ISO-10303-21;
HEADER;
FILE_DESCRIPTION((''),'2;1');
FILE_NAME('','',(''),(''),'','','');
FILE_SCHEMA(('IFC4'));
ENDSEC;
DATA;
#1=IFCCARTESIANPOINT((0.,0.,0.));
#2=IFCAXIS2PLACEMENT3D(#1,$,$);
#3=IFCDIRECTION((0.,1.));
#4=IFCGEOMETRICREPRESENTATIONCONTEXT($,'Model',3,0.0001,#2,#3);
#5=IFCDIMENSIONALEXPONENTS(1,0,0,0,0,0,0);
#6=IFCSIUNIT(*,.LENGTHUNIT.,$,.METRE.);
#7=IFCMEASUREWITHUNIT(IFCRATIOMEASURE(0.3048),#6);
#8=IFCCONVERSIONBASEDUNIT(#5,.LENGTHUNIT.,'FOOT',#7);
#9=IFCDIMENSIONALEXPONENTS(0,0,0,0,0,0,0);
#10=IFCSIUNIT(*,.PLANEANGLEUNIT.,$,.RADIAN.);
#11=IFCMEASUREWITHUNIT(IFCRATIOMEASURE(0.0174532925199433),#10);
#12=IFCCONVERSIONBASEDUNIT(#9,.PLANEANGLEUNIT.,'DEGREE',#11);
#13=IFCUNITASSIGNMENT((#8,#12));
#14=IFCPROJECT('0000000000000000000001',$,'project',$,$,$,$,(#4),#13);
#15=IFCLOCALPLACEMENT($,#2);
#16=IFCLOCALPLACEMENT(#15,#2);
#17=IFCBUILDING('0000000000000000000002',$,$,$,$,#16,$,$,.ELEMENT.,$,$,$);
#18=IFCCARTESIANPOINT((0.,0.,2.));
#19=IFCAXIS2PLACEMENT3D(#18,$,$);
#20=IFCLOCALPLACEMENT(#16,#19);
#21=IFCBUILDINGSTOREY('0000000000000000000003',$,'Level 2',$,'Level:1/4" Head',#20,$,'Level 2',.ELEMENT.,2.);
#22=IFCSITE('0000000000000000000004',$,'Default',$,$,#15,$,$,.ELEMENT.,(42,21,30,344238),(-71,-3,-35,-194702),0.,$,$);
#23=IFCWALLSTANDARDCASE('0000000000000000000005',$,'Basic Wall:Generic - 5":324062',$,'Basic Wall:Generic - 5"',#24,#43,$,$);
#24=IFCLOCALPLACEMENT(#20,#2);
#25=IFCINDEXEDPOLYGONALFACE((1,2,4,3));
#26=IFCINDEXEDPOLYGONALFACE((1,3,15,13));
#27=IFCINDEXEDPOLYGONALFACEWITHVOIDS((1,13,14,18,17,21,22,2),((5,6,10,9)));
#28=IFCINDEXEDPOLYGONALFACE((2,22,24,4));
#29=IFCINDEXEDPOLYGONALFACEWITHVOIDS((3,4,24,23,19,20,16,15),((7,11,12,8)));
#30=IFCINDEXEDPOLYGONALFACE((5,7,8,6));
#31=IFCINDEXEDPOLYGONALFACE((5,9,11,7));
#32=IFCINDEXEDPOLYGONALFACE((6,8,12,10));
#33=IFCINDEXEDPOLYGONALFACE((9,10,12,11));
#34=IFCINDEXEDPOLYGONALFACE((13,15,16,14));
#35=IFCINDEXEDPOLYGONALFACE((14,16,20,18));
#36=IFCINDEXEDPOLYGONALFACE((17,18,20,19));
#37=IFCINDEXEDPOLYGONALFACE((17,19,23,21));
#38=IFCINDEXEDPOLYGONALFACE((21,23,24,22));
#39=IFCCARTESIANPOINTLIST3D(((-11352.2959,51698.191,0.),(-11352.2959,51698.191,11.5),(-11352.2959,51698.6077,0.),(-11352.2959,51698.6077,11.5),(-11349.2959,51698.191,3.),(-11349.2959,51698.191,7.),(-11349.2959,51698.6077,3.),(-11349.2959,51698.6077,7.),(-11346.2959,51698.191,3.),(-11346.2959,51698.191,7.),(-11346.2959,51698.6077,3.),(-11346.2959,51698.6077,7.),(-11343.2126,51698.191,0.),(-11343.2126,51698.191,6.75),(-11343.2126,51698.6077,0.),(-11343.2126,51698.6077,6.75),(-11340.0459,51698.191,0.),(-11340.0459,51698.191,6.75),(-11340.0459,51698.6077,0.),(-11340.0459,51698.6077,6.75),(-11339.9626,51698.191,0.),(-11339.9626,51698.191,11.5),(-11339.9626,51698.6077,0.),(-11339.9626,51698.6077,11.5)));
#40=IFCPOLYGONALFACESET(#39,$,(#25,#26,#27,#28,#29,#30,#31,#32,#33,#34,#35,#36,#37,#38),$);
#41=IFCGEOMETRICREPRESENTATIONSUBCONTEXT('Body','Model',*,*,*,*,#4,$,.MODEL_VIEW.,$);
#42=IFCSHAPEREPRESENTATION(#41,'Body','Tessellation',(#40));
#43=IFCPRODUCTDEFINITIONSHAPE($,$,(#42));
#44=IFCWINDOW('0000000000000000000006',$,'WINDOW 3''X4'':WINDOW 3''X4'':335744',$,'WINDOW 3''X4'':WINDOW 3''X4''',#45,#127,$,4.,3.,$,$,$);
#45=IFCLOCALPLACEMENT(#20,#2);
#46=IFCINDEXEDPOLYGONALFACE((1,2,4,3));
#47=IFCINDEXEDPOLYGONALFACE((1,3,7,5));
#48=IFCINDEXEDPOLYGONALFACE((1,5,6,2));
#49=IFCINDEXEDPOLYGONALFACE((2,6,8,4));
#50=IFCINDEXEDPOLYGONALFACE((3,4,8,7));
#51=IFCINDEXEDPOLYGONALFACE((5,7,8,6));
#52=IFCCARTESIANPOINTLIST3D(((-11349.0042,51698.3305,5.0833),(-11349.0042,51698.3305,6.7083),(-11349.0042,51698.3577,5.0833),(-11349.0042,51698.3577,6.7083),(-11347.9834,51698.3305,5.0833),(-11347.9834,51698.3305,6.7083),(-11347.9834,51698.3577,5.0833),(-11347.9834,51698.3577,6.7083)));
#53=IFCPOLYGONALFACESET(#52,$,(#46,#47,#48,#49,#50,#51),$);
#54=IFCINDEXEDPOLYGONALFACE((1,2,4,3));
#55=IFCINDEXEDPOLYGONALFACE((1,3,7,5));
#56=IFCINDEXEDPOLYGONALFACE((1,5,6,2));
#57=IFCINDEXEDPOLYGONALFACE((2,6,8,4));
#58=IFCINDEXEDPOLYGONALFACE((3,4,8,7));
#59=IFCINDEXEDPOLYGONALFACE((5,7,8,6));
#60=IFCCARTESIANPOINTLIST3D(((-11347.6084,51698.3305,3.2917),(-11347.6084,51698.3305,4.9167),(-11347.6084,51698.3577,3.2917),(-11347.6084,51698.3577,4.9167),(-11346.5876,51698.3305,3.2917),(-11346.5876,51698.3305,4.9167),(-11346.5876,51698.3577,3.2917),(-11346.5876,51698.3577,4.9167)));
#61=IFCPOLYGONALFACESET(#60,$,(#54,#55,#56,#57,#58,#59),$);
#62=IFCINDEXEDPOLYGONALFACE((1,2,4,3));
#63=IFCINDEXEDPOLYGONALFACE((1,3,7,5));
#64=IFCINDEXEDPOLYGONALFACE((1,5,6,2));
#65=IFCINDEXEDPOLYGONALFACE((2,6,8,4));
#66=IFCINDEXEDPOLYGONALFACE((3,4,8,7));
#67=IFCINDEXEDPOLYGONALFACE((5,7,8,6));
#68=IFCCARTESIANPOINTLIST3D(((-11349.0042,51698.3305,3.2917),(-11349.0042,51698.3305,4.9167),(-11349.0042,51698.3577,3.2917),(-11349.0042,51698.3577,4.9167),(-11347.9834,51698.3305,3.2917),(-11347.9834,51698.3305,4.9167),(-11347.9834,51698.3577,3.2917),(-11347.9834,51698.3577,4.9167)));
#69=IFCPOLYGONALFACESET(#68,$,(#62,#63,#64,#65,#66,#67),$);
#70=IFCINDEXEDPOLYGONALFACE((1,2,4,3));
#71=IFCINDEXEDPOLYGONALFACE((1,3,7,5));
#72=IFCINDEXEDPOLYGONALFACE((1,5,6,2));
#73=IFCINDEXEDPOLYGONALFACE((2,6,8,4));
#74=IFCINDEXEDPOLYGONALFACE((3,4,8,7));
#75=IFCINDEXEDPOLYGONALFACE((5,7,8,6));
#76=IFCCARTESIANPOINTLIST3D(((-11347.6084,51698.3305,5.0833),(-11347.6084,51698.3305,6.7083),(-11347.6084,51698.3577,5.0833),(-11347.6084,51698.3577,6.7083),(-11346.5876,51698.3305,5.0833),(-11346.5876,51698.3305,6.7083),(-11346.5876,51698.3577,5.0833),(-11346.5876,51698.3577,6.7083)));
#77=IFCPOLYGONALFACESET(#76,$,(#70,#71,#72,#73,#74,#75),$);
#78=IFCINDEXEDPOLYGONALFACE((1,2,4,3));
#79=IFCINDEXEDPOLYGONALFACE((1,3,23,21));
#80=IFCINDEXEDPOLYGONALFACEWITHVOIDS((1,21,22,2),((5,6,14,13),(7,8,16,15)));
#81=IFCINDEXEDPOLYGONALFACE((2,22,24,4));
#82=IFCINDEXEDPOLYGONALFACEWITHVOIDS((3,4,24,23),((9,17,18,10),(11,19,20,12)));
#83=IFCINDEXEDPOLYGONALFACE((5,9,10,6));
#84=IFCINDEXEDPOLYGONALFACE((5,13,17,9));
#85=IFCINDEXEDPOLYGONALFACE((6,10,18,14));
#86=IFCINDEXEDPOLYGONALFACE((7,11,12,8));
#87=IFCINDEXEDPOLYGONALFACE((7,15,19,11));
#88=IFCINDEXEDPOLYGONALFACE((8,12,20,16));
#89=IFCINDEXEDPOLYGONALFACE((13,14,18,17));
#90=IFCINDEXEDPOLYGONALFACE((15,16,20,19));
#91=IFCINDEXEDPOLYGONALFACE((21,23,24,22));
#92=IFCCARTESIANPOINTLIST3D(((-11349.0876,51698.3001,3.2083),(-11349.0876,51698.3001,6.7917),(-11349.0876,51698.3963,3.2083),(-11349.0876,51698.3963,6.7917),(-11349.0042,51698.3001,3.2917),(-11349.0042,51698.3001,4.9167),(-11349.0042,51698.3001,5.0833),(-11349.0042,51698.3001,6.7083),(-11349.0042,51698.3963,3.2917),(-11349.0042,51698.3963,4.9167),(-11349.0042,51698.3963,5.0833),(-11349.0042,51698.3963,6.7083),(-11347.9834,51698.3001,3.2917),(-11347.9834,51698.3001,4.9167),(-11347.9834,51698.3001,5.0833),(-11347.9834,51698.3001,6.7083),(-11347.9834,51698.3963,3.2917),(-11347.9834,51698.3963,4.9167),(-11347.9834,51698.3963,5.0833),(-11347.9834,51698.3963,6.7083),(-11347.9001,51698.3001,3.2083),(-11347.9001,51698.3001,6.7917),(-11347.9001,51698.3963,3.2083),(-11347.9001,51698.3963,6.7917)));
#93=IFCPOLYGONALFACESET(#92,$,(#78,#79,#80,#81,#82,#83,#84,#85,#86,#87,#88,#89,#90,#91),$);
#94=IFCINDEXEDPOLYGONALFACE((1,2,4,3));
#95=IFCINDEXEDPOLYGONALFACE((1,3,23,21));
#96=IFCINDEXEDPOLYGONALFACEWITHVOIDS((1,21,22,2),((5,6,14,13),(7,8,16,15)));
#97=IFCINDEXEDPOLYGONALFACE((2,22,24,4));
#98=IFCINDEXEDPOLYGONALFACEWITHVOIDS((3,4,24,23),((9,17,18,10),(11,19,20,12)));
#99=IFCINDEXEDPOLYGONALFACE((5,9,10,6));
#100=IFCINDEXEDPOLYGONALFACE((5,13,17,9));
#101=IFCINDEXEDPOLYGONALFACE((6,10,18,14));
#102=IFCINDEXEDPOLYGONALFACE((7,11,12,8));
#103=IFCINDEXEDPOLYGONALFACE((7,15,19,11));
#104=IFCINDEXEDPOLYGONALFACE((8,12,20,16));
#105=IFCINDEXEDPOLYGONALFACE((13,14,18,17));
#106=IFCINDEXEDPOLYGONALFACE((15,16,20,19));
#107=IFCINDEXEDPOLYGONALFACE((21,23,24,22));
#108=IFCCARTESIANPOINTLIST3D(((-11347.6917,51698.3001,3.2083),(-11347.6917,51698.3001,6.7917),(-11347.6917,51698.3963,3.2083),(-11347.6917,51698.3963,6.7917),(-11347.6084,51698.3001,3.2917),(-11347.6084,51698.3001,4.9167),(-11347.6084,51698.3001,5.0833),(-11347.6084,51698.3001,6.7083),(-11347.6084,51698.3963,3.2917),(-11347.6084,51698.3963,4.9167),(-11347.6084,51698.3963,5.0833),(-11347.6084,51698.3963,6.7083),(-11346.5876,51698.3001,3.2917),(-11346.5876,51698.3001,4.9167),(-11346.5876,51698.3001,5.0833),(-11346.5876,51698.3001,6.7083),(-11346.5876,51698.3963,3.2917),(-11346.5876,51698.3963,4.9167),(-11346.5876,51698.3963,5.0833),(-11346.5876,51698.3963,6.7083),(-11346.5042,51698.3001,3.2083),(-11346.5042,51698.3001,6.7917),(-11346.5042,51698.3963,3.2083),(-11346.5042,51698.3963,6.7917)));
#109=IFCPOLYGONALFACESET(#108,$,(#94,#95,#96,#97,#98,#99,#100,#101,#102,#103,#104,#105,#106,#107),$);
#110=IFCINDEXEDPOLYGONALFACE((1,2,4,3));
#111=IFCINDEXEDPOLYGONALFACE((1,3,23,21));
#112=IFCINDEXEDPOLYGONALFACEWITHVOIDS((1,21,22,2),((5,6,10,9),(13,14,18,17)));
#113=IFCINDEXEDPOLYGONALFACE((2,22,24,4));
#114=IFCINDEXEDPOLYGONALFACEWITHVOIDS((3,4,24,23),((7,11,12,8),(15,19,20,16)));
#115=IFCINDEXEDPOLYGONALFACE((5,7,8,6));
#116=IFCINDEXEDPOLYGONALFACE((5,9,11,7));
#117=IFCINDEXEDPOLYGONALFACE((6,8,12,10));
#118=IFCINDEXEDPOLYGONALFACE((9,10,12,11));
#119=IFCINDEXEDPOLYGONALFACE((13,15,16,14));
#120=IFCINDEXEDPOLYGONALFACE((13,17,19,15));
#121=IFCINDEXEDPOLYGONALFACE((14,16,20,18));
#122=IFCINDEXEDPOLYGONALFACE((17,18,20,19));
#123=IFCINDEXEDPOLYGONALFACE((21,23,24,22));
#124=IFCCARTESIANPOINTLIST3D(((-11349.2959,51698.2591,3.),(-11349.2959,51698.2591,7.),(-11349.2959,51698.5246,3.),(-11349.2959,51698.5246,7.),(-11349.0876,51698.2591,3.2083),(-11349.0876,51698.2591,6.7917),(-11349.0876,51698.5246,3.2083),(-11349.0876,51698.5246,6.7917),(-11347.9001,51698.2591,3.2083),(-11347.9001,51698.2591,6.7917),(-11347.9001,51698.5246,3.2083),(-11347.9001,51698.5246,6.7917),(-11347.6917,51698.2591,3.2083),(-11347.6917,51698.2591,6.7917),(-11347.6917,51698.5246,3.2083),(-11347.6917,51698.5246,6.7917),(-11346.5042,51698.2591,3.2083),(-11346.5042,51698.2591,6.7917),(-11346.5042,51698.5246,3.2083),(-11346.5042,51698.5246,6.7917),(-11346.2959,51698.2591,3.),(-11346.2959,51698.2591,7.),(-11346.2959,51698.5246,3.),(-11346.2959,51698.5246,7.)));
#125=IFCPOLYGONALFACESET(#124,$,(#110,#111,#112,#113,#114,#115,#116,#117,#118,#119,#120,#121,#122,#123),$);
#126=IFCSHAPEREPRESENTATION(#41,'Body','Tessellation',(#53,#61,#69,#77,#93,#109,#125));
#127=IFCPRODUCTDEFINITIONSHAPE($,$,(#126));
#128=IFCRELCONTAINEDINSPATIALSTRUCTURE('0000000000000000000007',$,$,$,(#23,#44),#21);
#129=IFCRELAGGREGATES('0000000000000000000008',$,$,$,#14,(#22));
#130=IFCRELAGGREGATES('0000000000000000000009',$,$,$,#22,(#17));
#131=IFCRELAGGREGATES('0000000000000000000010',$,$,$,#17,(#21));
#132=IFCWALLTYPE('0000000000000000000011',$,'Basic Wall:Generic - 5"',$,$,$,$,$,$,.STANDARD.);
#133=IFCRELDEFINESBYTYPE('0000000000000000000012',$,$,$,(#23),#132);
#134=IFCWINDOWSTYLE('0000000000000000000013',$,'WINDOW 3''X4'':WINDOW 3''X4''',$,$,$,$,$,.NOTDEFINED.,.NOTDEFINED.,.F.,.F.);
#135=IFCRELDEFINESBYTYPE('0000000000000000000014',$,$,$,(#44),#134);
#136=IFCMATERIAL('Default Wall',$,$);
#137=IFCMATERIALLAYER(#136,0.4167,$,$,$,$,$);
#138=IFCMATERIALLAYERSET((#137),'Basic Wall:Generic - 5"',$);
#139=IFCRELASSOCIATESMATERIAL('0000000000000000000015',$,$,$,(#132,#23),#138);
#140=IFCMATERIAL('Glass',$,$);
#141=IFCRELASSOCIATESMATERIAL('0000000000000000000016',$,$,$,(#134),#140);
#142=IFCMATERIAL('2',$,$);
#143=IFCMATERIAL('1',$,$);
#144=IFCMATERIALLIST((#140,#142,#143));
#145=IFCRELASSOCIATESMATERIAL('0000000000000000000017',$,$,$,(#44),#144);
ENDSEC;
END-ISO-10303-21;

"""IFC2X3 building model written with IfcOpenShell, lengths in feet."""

from ifc_helpers import new_model, entity, si_unit, converted_unit, direction, frame, frame_2d, origin, origin_2d_with_axis, place, context, subcontext, project, spatial, polyline, rectangle, outline, extrude, source, transform, mapped, material, material_list, layer, layer_set, layer_usage, type_object, type_shapes, element, fill, save


model = new_model("IFC2X3")

# Units and contexts
model_context = context("Model", 3, precision=0.0001, world=origin(), true_north=direction((0.0, 1.0)))
body_context = subcontext(model_context, "Body", "Model", "MODEL_VIEW")
ifc_project = project(units=[converted_unit("LENGTHUNIT", "FOOT", entity("IfcRatioMeasure", 0.3048), si_unit("LENGTHUNIT", "METRE"), dimensions=[1, 0, 0, 0, 0, 0, 0]), converted_unit("PLANEANGLEUNIT", "DEGREE", entity("IfcRatioMeasure", 0.0174532925199433), si_unit("PLANEANGLEUNIT", "RADIAN"), dimensions=[0, 0, 0, 0, 0, 0, 0])], contexts=[model_context])

# Site, building, storey
site_placement = place(None, origin())
site = spatial("IfcSite", under=ifc_project, at=site_placement, Name="Default", CompositionType="ELEMENT", RefLatitude=(42, 21, 30, 344238), RefLongitude=(-71, -3, -35, -194702), RefElevation=0.0)
building_placement = place(site_placement, origin())
building = spatial("IfcBuilding", under=site, at=building_placement, CompositionType="ELEMENT")
storey_placement = place(building_placement, frame((0.0, 0.0, 2.0)))
storey = spatial("IfcBuildingStorey", under=building, at=storey_placement, Name="Level 2", ObjectType="Level:1/4\" Head", LongName="Level 2", CompositionType="ELEMENT", Elevation=2.0)

# Wall, openings, window
ifc_material_1 = material(Name="Default Wall")
ifc_layer_1 = layer(ifc_material_1, 0.4167)
ifc_layer_set_1 = layer_set([ifc_layer_1], Name="Basic Wall:Generic - 5\"")
wall_type = type_object("IfcWallType", Name="Basic Wall:Generic - 5\"", PredefinedType="STANDARD", material=ifc_layer_set_1)
ifc_material_2 = material(Name="Glass")
ifc_material_3 = material(Name="2")
ifc_material_4 = material(Name="1")
window_style = type_object("IfcWindowStyle", Name="WINDOW 3'X4':WINDOW 3'X4'", ConstructionType="NOTDEFINED", OperationType="NOTDEFINED", ParameterTakesPrecedence=False, Sizeable=False, material=ifc_material_2)
shared_shape = source(origin(), body_context, "Body", "SweptSolid", [
    extrude(rectangle(XDim=0.0272, YDim=1.0208, at=origin_2d_with_axis()), frame((2.1979, 0.2636, 2.0833), z_axis=(0.0, 0.0, 1.0), x_axis=(0.0, 1.0, 0.0)), (0.0, 0.0, 1.0), 1.625),
    extrude(rectangle(XDim=0.0272, YDim=1.0208, at=origin_2d_with_axis()), frame((0.8021, 0.2636, 0.2917), z_axis=(0.0, 0.0, 1.0), x_axis=(0.0, 1.0, 0.0)), (0.0, 0.0, 1.0), 1.625),
    extrude(rectangle(XDim=0.0272, YDim=1.0208, at=origin_2d_with_axis()), frame((2.1979, 0.2636, 0.2917), z_axis=(0.0, 0.0, 1.0), x_axis=(0.0, 1.0, 0.0)), (0.0, 0.0, 1.0), 1.625),
    extrude(rectangle(XDim=0.0272, YDim=1.0208, at=origin_2d_with_axis()), frame((0.8021, 0.2636, 2.0833), z_axis=(0.0, 0.0, 1.0), x_axis=(0.0, 1.0, 0.0)), (0.0, 0.0, 1.0), 1.625),
    extrude(outline(polyline([(-0.5938, -1.7917), (0.5938, -1.7917), (0.5938, 1.7917), (-0.5938, 1.7917), (-0.5938, -1.7917)]), holes=[polyline([(-0.5104, -0.0833), (0.5104, -0.0833), (0.5104, -1.7083), (-0.5104, -1.7083), (-0.5104, -0.0833)]), polyline([(-0.5104, 1.7083), (0.5104, 1.7083), (0.5104, 0.0833), (-0.5104, 0.0833), (-0.5104, 1.7083)])]), frame((2.1979, 0.2114, 2.0), z_axis=(0.0, 1.0, 0.0), x_axis=(-1.0, 0.0, 0.0)), (0.0, 0.0, 1.0), 0.0962),
    extrude(outline(polyline([(-1.7917, -0.5937), (1.7917, -0.5937), (1.7917, 0.5937), (-1.7917, 0.5937), (-1.7917, -0.5937)]), holes=[polyline([(0.0833, -0.5104), (0.0833, 0.5104), (1.7083, 0.5104), (1.7083, -0.5104), (0.0833, -0.5104)]), polyline([(-1.7083, -0.5104), (-1.7083, 0.5104), (-0.0833, 0.5104), (-0.0833, -0.5104), (-1.7083, -0.5104)])]), frame((0.8021, 0.2114, 2.0), z_axis=(0.0, 1.0, 0.0), x_axis=(0.0, 0.0, -1.0)), (0.0, 0.0, 1.0), 0.0962),
    extrude(outline(polyline([(-1.5, -2.0), (1.5, -2.0), (1.5, 2.0), (-1.5, 2.0), (-1.5, -2.0)]), holes=[polyline([(-0.1042, 1.7917), (-0.1042, -1.7917), (-1.2917, -1.7917), (-1.2917, 1.7917), (-0.1042, 1.7917)]), polyline([(0.1042, -1.7917), (0.1042, 1.7917), (1.2917, 1.7917), (1.2917, -1.7917), (0.1042, -1.7917)])]), frame((1.5, 0.0831, 2.0), z_axis=(0.0, 1.0, 0.0), x_axis=(1.0, 0.0, 0.0)), (0.0, 0.0, 1.0), 0.2655),
])
type_shapes(window_style, [shared_shape])
ifc_layer_usage_1 = layer_usage(ifc_layer_set_1, "AXIS2", "NEGATIVE", 0.2083)
wall_1_placement = place(storey_placement, frame((-11352.2959, 51698.3993, 0.0)))
wall_1 = element("IfcWallStandardCase", 1, at=wall_1_placement, inside=storey, type_object=wall_type, material=ifc_layer_usage_1, Name="Basic Wall:Generic - 5\":324062", ObjectType="Basic Wall:Generic - 5\"", context=body_context, shape_type="SweptSolid", body=[
    extrude(rectangle(XDim=12.3333, YDim=0.4167, at=frame_2d((6.1667, 0.0), x_axis=(-1.0, 0.0))), origin(), (0.0, 0.0, 1.0), 11.5),
])
opening_1_placement = place(wall_1_placement, frame((9.0833, -0.2083, 0.0)))
element("IfcOpeningElement", 2, at=opening_1_placement, cuts=wall_1, ObjectType="Opening", context=body_context, shape_type="SweptSolid", body=[
    extrude(rectangle(XDim=6.75, YDim=3.1667, at=frame_2d((3.375, 1.5833), x_axis=(1.0, 0.0))), frame((0.0, 0.0, 0.0), z_axis=(0.0, 1.0, 0.0), x_axis=(0.0, 0.0, 1.0)), (0.0, 0.0, 1.0), 0.4167),
])
opening_2_placement = place(wall_1_placement, frame((6.0, 0.2083, 3.0)))
opening_2 = element("IfcOpeningElement", 3, at=opening_2_placement, cuts=wall_1, ObjectType="Opening", context=body_context, shape_type="SweptSolid", body=[
    extrude(rectangle(XDim=4.0, YDim=3.0, at=frame_2d((2.0, 1.5), x_axis=(-1.0, 0.0))), frame((0.0, 0.0, 0.0), z_axis=(0.0, -1.0, 0.0), x_axis=(0.0, 0.0, 1.0)), (0.0, 0.0, 1.0), 0.4167),
])
ifc_material_list_1 = material_list([ifc_material_2, ifc_material_3, ifc_material_4])
window_1_placement = place(opening_2_placement, frame((0.0, 0.0, 0.0), z_axis=(0.0, 0.0, 1.0), x_axis=(-1.0, 0.0, 0.0)))
window_1 = element("IfcWindow", 4, at=window_1_placement, inside=storey, type_object=window_style, material=ifc_material_list_1, Name="WINDOW 3'X4':WINDOW 3'X4':335744", ObjectType="WINDOW 3'X4':WINDOW 3'X4'", OverallHeight=4.0, OverallWidth=3.0, context=body_context, shape_type="MappedRepresentation", body=[
    mapped(shared_shape, transform((0.0, 0.0, 0.0), scale=1.0)),
])
fill(opening_2, window_1)

save(model, "model.ifc")
